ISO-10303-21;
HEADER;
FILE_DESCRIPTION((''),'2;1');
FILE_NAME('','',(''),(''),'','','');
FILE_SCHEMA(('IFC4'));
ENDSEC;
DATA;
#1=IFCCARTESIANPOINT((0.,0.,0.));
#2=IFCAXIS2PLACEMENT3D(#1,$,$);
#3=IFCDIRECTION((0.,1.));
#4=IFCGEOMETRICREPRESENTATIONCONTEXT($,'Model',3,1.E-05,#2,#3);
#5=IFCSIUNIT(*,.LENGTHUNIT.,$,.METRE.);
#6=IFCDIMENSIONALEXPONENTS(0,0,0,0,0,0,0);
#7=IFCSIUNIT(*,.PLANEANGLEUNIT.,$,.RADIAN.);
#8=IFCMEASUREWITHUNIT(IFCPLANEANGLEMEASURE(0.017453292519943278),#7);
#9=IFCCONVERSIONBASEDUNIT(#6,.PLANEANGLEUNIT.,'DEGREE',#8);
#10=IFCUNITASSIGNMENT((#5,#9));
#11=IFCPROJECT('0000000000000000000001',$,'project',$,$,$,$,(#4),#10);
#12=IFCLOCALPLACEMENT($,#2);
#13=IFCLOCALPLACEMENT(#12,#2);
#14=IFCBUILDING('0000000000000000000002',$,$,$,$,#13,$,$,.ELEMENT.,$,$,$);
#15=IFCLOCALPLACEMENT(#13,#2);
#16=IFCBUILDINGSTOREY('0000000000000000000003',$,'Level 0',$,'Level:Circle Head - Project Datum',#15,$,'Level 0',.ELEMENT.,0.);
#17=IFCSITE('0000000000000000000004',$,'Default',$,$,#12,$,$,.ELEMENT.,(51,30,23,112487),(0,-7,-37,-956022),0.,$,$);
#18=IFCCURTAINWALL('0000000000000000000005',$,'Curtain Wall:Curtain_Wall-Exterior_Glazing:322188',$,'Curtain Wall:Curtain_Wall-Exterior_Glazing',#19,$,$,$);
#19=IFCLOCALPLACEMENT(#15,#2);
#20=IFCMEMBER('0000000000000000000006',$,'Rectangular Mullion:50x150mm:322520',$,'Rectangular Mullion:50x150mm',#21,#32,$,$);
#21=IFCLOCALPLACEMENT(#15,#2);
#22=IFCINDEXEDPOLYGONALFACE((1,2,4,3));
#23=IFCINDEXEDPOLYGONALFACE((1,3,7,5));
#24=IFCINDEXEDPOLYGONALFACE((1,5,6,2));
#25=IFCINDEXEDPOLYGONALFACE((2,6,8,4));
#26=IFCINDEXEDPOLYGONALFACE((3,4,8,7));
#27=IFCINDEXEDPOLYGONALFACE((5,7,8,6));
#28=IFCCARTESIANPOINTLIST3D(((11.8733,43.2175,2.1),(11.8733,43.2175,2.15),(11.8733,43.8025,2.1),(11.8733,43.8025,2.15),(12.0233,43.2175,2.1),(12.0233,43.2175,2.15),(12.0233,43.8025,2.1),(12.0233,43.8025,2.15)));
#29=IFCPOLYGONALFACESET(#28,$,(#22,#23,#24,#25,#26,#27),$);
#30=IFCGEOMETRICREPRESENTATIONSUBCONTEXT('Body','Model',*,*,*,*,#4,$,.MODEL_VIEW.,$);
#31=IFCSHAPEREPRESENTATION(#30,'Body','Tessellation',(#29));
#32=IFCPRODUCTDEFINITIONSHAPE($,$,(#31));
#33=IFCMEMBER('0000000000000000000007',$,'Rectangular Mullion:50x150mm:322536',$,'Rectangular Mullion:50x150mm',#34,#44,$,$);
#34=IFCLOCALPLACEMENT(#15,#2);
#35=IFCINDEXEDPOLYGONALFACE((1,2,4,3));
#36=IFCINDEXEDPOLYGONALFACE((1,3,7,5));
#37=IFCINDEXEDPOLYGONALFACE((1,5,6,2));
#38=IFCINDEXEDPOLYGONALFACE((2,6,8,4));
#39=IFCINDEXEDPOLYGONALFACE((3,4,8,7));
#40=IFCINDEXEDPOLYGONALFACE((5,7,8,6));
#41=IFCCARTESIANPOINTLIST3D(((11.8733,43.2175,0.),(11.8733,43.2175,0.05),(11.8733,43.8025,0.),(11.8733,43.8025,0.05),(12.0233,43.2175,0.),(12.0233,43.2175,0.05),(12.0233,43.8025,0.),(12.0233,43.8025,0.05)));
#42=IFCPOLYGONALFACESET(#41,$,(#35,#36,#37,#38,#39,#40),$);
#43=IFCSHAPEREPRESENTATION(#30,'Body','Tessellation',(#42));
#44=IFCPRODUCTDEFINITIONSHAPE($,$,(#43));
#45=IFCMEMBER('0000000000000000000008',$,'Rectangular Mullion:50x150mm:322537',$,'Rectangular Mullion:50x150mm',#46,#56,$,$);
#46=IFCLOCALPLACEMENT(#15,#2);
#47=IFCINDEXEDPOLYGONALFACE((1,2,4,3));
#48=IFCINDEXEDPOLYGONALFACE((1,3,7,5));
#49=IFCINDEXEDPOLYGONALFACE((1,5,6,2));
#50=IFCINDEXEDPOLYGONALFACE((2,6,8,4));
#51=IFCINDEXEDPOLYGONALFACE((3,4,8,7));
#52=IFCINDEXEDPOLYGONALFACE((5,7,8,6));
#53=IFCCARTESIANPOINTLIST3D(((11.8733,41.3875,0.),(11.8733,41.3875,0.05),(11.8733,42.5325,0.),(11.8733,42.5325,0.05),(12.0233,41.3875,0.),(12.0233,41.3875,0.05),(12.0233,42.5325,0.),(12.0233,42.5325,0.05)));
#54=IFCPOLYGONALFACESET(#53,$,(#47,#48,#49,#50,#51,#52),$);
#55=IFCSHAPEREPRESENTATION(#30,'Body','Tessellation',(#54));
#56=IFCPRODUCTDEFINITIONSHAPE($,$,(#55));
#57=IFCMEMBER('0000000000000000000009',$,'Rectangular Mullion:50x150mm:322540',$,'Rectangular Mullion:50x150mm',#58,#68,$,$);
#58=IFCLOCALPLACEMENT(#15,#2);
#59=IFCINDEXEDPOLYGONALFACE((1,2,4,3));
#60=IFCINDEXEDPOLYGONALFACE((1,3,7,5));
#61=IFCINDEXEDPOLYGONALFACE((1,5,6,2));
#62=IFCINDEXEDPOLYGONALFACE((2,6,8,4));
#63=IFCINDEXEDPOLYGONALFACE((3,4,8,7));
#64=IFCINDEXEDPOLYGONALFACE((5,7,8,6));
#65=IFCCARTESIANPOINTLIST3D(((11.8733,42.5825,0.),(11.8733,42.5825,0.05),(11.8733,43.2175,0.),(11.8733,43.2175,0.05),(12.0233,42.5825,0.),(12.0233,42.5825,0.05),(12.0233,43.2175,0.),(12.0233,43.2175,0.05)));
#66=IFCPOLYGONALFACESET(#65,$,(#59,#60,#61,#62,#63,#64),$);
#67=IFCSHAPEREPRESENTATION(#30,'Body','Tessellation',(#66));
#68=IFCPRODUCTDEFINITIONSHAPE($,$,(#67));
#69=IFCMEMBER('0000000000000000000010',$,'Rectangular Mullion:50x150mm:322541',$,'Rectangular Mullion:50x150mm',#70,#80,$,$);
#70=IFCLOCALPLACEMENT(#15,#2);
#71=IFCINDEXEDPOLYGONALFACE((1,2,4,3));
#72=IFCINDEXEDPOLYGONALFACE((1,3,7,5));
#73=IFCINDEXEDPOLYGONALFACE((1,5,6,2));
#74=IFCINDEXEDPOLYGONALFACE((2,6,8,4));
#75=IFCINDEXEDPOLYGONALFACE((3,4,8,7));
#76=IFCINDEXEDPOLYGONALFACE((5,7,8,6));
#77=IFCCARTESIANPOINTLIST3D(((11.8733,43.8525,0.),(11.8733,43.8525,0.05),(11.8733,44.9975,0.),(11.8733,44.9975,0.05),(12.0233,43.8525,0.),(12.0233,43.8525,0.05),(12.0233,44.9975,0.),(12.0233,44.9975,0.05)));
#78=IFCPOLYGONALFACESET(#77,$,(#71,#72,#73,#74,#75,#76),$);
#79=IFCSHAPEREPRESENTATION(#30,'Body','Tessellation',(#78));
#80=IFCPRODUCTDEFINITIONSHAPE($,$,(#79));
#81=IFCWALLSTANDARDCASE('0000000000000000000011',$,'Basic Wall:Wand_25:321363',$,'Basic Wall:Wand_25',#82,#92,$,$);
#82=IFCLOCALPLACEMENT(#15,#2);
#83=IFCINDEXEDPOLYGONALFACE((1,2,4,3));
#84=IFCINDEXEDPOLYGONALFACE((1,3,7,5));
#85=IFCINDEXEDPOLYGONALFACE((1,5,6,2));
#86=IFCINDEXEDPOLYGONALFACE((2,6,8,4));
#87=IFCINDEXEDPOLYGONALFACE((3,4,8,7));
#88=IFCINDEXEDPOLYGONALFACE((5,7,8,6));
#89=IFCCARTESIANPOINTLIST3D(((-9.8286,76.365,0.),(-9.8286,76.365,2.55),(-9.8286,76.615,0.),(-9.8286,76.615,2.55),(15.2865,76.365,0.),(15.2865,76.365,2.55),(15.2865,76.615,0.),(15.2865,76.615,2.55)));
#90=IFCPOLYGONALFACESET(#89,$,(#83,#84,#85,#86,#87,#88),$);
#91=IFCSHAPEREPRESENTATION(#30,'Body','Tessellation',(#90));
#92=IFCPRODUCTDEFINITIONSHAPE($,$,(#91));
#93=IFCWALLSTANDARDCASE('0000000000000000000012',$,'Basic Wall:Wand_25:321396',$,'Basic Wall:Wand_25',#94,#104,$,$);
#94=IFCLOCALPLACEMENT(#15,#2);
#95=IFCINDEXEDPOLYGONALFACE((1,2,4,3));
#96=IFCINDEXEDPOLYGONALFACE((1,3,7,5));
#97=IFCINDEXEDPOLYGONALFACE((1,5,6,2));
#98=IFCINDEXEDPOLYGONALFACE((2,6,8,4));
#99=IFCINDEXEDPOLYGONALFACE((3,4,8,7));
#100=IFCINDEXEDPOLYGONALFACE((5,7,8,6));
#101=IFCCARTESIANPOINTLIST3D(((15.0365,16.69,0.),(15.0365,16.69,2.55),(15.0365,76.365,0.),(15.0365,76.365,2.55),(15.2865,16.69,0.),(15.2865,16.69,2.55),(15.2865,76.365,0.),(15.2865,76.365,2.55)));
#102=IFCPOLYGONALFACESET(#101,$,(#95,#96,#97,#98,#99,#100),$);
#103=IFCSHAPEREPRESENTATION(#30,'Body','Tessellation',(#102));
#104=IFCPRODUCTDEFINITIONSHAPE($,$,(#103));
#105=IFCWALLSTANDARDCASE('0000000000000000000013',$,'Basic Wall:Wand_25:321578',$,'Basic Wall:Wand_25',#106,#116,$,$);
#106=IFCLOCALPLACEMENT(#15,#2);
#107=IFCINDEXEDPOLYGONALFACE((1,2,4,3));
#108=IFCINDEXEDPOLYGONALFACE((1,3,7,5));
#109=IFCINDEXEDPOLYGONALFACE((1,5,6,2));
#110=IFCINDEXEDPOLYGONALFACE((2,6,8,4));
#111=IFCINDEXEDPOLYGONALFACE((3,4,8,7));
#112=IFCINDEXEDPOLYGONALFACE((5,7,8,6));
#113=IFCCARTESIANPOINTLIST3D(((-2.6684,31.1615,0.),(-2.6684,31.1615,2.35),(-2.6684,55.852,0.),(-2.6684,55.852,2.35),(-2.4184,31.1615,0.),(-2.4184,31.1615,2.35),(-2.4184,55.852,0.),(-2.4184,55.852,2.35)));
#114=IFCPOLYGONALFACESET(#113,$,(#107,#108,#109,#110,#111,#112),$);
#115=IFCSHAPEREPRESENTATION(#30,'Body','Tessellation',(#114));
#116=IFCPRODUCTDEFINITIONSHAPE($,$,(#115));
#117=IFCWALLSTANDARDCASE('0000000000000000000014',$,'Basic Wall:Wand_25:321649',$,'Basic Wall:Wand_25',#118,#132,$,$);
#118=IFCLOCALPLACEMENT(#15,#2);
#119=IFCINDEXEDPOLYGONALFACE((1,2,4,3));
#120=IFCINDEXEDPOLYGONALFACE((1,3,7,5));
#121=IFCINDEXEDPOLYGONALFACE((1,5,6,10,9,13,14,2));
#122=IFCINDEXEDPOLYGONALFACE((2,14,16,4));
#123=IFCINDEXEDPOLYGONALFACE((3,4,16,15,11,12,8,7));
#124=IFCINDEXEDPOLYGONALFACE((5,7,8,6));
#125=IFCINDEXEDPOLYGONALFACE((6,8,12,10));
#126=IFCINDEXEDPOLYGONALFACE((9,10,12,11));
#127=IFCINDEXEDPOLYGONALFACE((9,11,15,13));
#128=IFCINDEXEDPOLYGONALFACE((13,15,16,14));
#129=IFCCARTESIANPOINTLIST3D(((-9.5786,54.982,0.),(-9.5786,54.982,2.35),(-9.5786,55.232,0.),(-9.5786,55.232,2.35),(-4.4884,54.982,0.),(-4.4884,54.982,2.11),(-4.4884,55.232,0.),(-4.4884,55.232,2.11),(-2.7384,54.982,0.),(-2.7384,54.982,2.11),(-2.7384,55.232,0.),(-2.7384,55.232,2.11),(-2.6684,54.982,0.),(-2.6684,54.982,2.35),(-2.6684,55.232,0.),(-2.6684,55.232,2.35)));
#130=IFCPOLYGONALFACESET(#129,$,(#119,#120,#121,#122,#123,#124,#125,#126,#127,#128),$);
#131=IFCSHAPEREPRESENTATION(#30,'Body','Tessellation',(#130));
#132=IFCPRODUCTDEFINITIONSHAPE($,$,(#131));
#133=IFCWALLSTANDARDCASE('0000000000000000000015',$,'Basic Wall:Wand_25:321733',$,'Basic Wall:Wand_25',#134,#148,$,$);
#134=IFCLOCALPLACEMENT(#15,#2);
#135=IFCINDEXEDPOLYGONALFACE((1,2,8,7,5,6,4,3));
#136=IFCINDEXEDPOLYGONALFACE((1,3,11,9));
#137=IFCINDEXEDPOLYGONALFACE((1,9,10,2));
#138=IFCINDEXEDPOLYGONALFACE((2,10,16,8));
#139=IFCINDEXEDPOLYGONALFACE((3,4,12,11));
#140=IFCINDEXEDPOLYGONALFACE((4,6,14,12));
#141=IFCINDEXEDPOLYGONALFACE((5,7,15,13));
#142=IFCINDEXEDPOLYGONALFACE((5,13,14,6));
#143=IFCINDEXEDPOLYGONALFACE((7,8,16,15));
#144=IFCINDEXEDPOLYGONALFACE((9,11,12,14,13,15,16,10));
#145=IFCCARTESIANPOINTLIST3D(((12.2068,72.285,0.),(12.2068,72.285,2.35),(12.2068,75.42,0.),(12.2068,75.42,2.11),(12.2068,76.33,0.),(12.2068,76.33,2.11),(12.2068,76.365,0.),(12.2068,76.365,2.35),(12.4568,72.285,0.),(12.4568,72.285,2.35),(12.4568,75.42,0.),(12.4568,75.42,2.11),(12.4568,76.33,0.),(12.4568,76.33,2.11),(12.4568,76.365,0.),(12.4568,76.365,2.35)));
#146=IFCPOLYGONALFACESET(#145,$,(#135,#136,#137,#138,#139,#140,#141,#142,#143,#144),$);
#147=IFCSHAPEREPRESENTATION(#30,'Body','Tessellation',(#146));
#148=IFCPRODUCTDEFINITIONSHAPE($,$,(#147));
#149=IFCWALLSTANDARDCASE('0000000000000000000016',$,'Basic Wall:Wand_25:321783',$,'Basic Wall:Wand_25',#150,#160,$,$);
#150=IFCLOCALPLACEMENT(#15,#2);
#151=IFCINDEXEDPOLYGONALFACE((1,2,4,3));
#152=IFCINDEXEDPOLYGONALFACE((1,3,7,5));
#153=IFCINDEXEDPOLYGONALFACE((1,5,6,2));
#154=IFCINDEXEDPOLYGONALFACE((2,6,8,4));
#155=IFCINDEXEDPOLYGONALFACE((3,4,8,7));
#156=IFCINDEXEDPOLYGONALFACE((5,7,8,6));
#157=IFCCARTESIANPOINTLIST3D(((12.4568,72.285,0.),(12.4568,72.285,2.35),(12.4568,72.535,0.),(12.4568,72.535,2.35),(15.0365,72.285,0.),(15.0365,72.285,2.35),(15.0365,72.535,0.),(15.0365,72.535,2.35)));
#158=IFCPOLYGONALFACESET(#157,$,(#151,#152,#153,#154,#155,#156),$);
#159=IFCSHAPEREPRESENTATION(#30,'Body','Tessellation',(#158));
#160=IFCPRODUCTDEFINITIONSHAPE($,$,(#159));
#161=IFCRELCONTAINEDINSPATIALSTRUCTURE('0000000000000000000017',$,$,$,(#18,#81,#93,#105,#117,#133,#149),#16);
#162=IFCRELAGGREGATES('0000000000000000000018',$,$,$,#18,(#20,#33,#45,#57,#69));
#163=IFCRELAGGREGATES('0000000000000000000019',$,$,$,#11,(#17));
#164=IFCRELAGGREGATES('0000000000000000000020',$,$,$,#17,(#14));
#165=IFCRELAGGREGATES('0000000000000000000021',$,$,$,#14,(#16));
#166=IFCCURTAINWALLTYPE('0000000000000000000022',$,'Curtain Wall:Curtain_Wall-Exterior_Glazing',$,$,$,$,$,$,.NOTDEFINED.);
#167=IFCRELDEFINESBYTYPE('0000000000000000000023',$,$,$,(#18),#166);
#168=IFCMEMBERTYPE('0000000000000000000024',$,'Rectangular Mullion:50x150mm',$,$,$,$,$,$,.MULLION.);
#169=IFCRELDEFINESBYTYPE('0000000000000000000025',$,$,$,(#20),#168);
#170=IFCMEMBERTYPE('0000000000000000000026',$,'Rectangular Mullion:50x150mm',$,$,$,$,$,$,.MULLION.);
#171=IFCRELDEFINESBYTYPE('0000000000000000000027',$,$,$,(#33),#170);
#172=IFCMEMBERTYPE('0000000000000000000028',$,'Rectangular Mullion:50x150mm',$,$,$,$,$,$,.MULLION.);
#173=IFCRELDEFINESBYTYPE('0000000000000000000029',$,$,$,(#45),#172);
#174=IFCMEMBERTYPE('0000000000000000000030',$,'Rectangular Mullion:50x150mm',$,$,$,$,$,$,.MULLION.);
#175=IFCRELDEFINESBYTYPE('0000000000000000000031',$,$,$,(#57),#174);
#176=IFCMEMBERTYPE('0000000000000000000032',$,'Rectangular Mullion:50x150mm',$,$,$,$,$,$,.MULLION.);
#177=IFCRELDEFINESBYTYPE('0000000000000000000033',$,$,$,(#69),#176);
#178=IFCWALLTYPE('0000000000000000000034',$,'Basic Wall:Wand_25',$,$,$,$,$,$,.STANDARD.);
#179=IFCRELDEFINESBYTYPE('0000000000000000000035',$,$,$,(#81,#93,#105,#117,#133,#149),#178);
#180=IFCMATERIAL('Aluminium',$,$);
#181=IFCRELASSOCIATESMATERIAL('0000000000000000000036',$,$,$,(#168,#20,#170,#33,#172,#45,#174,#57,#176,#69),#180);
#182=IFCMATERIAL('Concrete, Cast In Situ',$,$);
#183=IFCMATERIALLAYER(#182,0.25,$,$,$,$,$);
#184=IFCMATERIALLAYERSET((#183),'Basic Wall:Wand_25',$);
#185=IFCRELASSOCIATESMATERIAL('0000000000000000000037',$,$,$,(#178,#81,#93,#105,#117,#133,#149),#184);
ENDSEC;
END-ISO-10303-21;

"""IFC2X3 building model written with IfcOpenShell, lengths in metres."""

from ifc_helpers import new_model, entity, si_unit, converted_unit, direction, frame, frame_2d, origin, origin_2d_with_axis, place, context, subcontext, project, spatial, rectangle, extrude, source, transform, mapped, material, layer, layer_set, layer_usage, type_object, type_shapes, element, aggregate, save


model = new_model("IFC2X3")

# Units and contexts
model_context = context("Model", 3, precision=1e-05, world=origin(), true_north=direction((0.0, 1.0)))
body_context = subcontext(model_context, "Body", "Model", "MODEL_VIEW")
ifc_project = project(units=[si_unit("LENGTHUNIT", "METRE"), converted_unit("PLANEANGLEUNIT", "DEGREE", entity("IfcPlaneAngleMeasure", 0.017453292519943278), si_unit("PLANEANGLEUNIT", "RADIAN"), dimensions=[0, 0, 0, 0, 0, 0, 0])], contexts=[model_context])

# Site, building, storey
site_placement = place(None, origin())
site = spatial("IfcSite", under=ifc_project, at=site_placement, Name="Default", CompositionType="ELEMENT", RefLatitude=(51, 30, 23, 112487), RefLongitude=(0, -7, -37, -956022), RefElevation=0.0)
building_placement = place(site_placement, origin())
building = spatial("IfcBuilding", under=site, at=building_placement, CompositionType="ELEMENT")
storey_placement = place(building_placement, origin())
storey = spatial("IfcBuildingStorey", under=building, at=storey_placement, Name="Level 0", ObjectType="Level:Circle Head - Project Datum", LongName="Level 0", CompositionType="ELEMENT", Elevation=0.0)

# Curtain wall, members
curtain_wall_type = type_object("IfcCurtainWallType", Name="Curtain Wall:Curtain_Wall-Exterior_Glazing", PredefinedType="NOTDEFINED")
curtain_wall_placement = place(storey_placement, origin())
curtain_wall = element("IfcCurtainWall", 1, at=curtain_wall_placement, inside=storey, type_object=curtain_wall_type, Name="Curtain Wall:Curtain_Wall-Exterior_Glazing:322188", ObjectType="Curtain Wall:Curtain_Wall-Exterior_Glazing")
ifc_material_1 = material(Name="Aluminium")
member_type_1 = type_object("IfcMemberType", Name="Rectangular Mullion:50x150mm", PredefinedType="MULLION", material=ifc_material_1)
shared_shape_1 = source(origin(), body_context, "Body", "SweptSolid", [
    extrude(rectangle(XDim=0.05, YDim=0.15, at=origin_2d_with_axis()), frame((-0.025, 0.0, -0.585), z_axis=(0.0, 0.0, 1.0), x_axis=(-1.0, 0.0, 0.0)), (0.0, 0.0, 1.0), 0.585),
])
type_shapes(member_type_1, [shared_shape_1])
member_1_placement = place(curtain_wall_placement, frame((11.9483, 43.2175, 2.15), z_axis=(0.0, -1.0, 0.0), x_axis=(0.0, 0.0, 1.0)))
member_1 = element("IfcMember", 2, at=member_1_placement, type_object=member_type_1, material=ifc_material_1, Name="Rectangular Mullion:50x150mm:322520", ObjectType="Rectangular Mullion:50x150mm", context=body_context, shape_type="MappedRepresentation", body=[
    mapped(shared_shape_1, transform((0.0, 0.0, 0.0), scale=1.0)),
])
member_type_2 = type_object("IfcMemberType", Name="Rectangular Mullion:50x150mm", PredefinedType="MULLION", material=ifc_material_1)
shared_shape_2 = source(origin(), body_context, "Body", "SweptSolid", [
    extrude(rectangle(XDim=0.05, YDim=0.15, at=origin_2d_with_axis()), frame((-0.025, 0.0, -0.585), z_axis=(0.0, 0.0, 1.0), x_axis=(-1.0, 0.0, 0.0)), (0.0, 0.0, 1.0), 0.585),
])
type_shapes(member_type_2, [shared_shape_2])
member_2_placement = place(curtain_wall_placement, frame((11.9483, 43.8025, 0.0), z_axis=(0.0, 1.0, 0.0), x_axis=(0.0, 0.0, -1.0)))
member_2 = element("IfcMember", 3, at=member_2_placement, type_object=member_type_2, material=ifc_material_1, Name="Rectangular Mullion:50x150mm:322536", ObjectType="Rectangular Mullion:50x150mm", context=body_context, shape_type="MappedRepresentation", body=[
    mapped(shared_shape_2, transform((0.0, 0.0, 0.0), scale=1.0)),
])
member_type_3 = type_object("IfcMemberType", Name="Rectangular Mullion:50x150mm", PredefinedType="MULLION", material=ifc_material_1)
shared_shape_3 = source(origin(), body_context, "Body", "SweptSolid", [
    extrude(rectangle(XDim=0.05, YDim=0.15, at=origin_2d_with_axis()), frame((-0.025, 0.0, -1.145), z_axis=(0.0, 0.0, 1.0), x_axis=(-1.0, 0.0, 0.0)), (0.0, 0.0, 1.0), 1.145),
])
type_shapes(member_type_3, [shared_shape_3])
member_3_placement = place(curtain_wall_placement, frame((11.9483, 42.5325, 0.0), z_axis=(0.0, 1.0, 0.0), x_axis=(0.0, 0.0, -1.0)))
member_3 = element("IfcMember", 4, at=member_3_placement, type_object=member_type_3, material=ifc_material_1, Name="Rectangular Mullion:50x150mm:322537", ObjectType="Rectangular Mullion:50x150mm", context=body_context, shape_type="MappedRepresentation", body=[
    mapped(shared_shape_3, transform((0.0, 0.0, 0.0), scale=1.0)),
])
member_type_4 = type_object("IfcMemberType", Name="Rectangular Mullion:50x150mm", PredefinedType="MULLION", material=ifc_material_1)
shared_shape_4 = source(origin(), body_context, "Body", "SweptSolid", [
    extrude(rectangle(XDim=0.05, YDim=0.15, at=origin_2d_with_axis()), frame((-0.025, 0.0, -0.635), z_axis=(0.0, 0.0, 1.0), x_axis=(-1.0, 0.0, 0.0)), (0.0, 0.0, 1.0), 0.635),
])
type_shapes(member_type_4, [shared_shape_4])
member_4_placement = place(curtain_wall_placement, frame((11.9483, 43.2175, 0.0), z_axis=(0.0, 1.0, 0.0), x_axis=(0.0, 0.0, -1.0)))
member_4 = element("IfcMember", 5, at=member_4_placement, type_object=member_type_4, material=ifc_material_1, Name="Rectangular Mullion:50x150mm:322540", ObjectType="Rectangular Mullion:50x150mm", context=body_context, shape_type="MappedRepresentation", body=[
    mapped(shared_shape_4, transform((0.0, 0.0, 0.0), scale=1.0)),
])
member_type_5 = type_object("IfcMemberType", Name="Rectangular Mullion:50x150mm", PredefinedType="MULLION", material=ifc_material_1)
shared_shape_5 = source(origin(), body_context, "Body", "SweptSolid", [
    extrude(rectangle(XDim=0.05, YDim=0.15, at=origin_2d_with_axis()), frame((-0.025, 0.0, -1.145), z_axis=(0.0, 0.0, 1.0), x_axis=(-1.0, 0.0, 0.0)), (0.0, 0.0, 1.0), 1.145),
])
type_shapes(member_type_5, [shared_shape_5])
member_5_placement = place(curtain_wall_placement, frame((11.9483, 44.9975, 0.0), z_axis=(0.0, 1.0, 0.0), x_axis=(0.0, 0.0, -1.0)))
member_5 = element("IfcMember", 6, at=member_5_placement, type_object=member_type_5, material=ifc_material_1, Name="Rectangular Mullion:50x150mm:322541", ObjectType="Rectangular Mullion:50x150mm", context=body_context, shape_type="MappedRepresentation", body=[
    mapped(shared_shape_5, transform((0.0, 0.0, 0.0), scale=1.0)),
])
aggregate(curtain_wall, [member_1, member_2, member_3, member_4, member_5])

# Walls
ifc_material_2 = material(Name="Concrete, Cast In Situ")
ifc_layer_1 = layer(ifc_material_2, 0.25)
ifc_layer_set_1 = layer_set([ifc_layer_1], Name="Basic Wall:Wand_25")
ifc_layer_usage_1 = layer_usage(ifc_layer_set_1, "AXIS2", "NEGATIVE", 0.125)
wall_type_1 = type_object("IfcWallType", Name="Basic Wall:Wand_25", PredefinedType="STANDARD", material=ifc_layer_set_1)
wall_1_placement = place(storey_placement, frame((-9.8286, 76.49, 0.0)))
element("IfcWallStandardCase", 7, at=wall_1_placement, inside=storey, type_object=wall_type_1, material=ifc_layer_usage_1, Name="Basic Wall:Wand_25:321363", ObjectType="Basic Wall:Wand_25", context=body_context, shape_type="SweptSolid", body=[
    extrude(rectangle(XDim=25.1151, YDim=0.25, at=frame_2d((12.5576, 0.0), x_axis=(-1.0, 0.0))), origin(), (0.0, 0.0, 1.0), 2.55),
])
wall_2_placement = place(storey_placement, frame((15.1615, 76.365, 0.0), z_axis=(0.0, 0.0, 1.0), x_axis=(0.0, -1.0, 0.0)))
element("IfcWallStandardCase", 8, at=wall_2_placement, inside=storey, type_object=wall_type_1, material=ifc_layer_usage_1, Name="Basic Wall:Wand_25:321396", ObjectType="Basic Wall:Wand_25", context=body_context, shape_type="SweptSolid", body=[
    extrude(rectangle(XDim=59.675, YDim=0.25, at=frame_2d((29.8375, 0.0), x_axis=(-1.0, 0.0))), origin(), (0.0, 0.0, 1.0), 2.55),
])
wall_3_placement = place(storey_placement, frame((-2.5434, 55.852, 0.0), z_axis=(0.0, 0.0, 1.0), x_axis=(0.0, -1.0, 0.0)))
element("IfcWallStandardCase", 9, at=wall_3_placement, inside=storey, type_object=wall_type_1, material=ifc_layer_usage_1, Name="Basic Wall:Wand_25:321578", ObjectType="Basic Wall:Wand_25", context=body_context, shape_type="SweptSolid", body=[
    extrude(rectangle(XDim=24.6905, YDim=0.25, at=frame_2d((12.3452, 0.0), x_axis=(-1.0, 0.0))), origin(), (0.0, 0.0, 1.0), 2.35),
])

# Walls, openings
wall_4_placement = place(storey_placement, frame((-2.6684, 55.107, 0.0), z_axis=(0.0, 0.0, 1.0), x_axis=(-1.0, 0.0, 0.0)))
wall_4 = element("IfcWallStandardCase", 10, at=wall_4_placement, inside=storey, type_object=wall_type_1, material=ifc_layer_usage_1, Name="Basic Wall:Wand_25:321649", ObjectType="Basic Wall:Wand_25", context=body_context, shape_type="SweptSolid", body=[
    extrude(rectangle(XDim=6.9102, YDim=0.25, at=frame_2d((3.4551, 0.0), x_axis=(1.0, 0.0))), origin(), (0.0, 0.0, 1.0), 2.35),
])
opening_1_placement = place(wall_4_placement, frame((1.82, 0.125, 0.0)))
element("IfcOpeningElement", 11, at=opening_1_placement, cuts=wall_4, ObjectType="Opening", context=body_context, shape_type="SweptSolid", body=[
    extrude(rectangle(XDim=2.11, YDim=1.75, at=frame_2d((1.055, 0.875), x_axis=(-1.0, 0.0))), frame((0.0, 0.0, 0.0), z_axis=(0.0, -1.0, 0.0), x_axis=(0.0, 0.0, 1.0)), (0.0, 0.0, 1.0), 0.25),
])
wall_5_placement = place(storey_placement, frame((12.3318, 76.365, 0.0), z_axis=(0.0, 0.0, 1.0), x_axis=(0.0, -1.0, 0.0)))
wall_5 = element("IfcWallStandardCase", 12, at=wall_5_placement, inside=storey, type_object=wall_type_1, material=ifc_layer_usage_1, Name="Basic Wall:Wand_25:321733", ObjectType="Basic Wall:Wand_25", context=body_context, shape_type="SweptSolid", body=[
    extrude(rectangle(XDim=4.08, YDim=0.25, at=frame_2d((2.04, 0.0), x_axis=(-1.0, 0.0))), origin(), (0.0, 0.0, 1.0), 2.35),
])
opening_2_placement = place(wall_5_placement, frame((0.945, 0.125, 0.0)))
element("IfcOpeningElement", 13, at=opening_2_placement, cuts=wall_5, ObjectType="Opening", context=body_context, shape_type="SweptSolid", body=[
    extrude(rectangle(XDim=2.11, YDim=0.91, at=frame_2d((1.055, 0.455), x_axis=(1.0, 0.0))), frame((0.0, 0.0, 0.0), z_axis=(0.0, -1.0, 0.0), x_axis=(0.0, 0.0, 1.0)), (0.0, 0.0, 1.0), 0.25),
])

# Wall
wall_6_placement = place(storey_placement, frame((12.4568, 72.41, 0.0)))
element("IfcWallStandardCase", 14, at=wall_6_placement, inside=storey, type_object=wall_type_1, material=ifc_layer_usage_1, Name="Basic Wall:Wand_25:321783", ObjectType="Basic Wall:Wand_25", context=body_context, shape_type="SweptSolid", body=[
    extrude(rectangle(XDim=2.5797, YDim=0.25, at=frame_2d((1.2898, 0.0), x_axis=(-1.0, 0.0))), origin(), (0.0, 0.0, 1.0), 2.35),
])

save(model, "model.ifc")
